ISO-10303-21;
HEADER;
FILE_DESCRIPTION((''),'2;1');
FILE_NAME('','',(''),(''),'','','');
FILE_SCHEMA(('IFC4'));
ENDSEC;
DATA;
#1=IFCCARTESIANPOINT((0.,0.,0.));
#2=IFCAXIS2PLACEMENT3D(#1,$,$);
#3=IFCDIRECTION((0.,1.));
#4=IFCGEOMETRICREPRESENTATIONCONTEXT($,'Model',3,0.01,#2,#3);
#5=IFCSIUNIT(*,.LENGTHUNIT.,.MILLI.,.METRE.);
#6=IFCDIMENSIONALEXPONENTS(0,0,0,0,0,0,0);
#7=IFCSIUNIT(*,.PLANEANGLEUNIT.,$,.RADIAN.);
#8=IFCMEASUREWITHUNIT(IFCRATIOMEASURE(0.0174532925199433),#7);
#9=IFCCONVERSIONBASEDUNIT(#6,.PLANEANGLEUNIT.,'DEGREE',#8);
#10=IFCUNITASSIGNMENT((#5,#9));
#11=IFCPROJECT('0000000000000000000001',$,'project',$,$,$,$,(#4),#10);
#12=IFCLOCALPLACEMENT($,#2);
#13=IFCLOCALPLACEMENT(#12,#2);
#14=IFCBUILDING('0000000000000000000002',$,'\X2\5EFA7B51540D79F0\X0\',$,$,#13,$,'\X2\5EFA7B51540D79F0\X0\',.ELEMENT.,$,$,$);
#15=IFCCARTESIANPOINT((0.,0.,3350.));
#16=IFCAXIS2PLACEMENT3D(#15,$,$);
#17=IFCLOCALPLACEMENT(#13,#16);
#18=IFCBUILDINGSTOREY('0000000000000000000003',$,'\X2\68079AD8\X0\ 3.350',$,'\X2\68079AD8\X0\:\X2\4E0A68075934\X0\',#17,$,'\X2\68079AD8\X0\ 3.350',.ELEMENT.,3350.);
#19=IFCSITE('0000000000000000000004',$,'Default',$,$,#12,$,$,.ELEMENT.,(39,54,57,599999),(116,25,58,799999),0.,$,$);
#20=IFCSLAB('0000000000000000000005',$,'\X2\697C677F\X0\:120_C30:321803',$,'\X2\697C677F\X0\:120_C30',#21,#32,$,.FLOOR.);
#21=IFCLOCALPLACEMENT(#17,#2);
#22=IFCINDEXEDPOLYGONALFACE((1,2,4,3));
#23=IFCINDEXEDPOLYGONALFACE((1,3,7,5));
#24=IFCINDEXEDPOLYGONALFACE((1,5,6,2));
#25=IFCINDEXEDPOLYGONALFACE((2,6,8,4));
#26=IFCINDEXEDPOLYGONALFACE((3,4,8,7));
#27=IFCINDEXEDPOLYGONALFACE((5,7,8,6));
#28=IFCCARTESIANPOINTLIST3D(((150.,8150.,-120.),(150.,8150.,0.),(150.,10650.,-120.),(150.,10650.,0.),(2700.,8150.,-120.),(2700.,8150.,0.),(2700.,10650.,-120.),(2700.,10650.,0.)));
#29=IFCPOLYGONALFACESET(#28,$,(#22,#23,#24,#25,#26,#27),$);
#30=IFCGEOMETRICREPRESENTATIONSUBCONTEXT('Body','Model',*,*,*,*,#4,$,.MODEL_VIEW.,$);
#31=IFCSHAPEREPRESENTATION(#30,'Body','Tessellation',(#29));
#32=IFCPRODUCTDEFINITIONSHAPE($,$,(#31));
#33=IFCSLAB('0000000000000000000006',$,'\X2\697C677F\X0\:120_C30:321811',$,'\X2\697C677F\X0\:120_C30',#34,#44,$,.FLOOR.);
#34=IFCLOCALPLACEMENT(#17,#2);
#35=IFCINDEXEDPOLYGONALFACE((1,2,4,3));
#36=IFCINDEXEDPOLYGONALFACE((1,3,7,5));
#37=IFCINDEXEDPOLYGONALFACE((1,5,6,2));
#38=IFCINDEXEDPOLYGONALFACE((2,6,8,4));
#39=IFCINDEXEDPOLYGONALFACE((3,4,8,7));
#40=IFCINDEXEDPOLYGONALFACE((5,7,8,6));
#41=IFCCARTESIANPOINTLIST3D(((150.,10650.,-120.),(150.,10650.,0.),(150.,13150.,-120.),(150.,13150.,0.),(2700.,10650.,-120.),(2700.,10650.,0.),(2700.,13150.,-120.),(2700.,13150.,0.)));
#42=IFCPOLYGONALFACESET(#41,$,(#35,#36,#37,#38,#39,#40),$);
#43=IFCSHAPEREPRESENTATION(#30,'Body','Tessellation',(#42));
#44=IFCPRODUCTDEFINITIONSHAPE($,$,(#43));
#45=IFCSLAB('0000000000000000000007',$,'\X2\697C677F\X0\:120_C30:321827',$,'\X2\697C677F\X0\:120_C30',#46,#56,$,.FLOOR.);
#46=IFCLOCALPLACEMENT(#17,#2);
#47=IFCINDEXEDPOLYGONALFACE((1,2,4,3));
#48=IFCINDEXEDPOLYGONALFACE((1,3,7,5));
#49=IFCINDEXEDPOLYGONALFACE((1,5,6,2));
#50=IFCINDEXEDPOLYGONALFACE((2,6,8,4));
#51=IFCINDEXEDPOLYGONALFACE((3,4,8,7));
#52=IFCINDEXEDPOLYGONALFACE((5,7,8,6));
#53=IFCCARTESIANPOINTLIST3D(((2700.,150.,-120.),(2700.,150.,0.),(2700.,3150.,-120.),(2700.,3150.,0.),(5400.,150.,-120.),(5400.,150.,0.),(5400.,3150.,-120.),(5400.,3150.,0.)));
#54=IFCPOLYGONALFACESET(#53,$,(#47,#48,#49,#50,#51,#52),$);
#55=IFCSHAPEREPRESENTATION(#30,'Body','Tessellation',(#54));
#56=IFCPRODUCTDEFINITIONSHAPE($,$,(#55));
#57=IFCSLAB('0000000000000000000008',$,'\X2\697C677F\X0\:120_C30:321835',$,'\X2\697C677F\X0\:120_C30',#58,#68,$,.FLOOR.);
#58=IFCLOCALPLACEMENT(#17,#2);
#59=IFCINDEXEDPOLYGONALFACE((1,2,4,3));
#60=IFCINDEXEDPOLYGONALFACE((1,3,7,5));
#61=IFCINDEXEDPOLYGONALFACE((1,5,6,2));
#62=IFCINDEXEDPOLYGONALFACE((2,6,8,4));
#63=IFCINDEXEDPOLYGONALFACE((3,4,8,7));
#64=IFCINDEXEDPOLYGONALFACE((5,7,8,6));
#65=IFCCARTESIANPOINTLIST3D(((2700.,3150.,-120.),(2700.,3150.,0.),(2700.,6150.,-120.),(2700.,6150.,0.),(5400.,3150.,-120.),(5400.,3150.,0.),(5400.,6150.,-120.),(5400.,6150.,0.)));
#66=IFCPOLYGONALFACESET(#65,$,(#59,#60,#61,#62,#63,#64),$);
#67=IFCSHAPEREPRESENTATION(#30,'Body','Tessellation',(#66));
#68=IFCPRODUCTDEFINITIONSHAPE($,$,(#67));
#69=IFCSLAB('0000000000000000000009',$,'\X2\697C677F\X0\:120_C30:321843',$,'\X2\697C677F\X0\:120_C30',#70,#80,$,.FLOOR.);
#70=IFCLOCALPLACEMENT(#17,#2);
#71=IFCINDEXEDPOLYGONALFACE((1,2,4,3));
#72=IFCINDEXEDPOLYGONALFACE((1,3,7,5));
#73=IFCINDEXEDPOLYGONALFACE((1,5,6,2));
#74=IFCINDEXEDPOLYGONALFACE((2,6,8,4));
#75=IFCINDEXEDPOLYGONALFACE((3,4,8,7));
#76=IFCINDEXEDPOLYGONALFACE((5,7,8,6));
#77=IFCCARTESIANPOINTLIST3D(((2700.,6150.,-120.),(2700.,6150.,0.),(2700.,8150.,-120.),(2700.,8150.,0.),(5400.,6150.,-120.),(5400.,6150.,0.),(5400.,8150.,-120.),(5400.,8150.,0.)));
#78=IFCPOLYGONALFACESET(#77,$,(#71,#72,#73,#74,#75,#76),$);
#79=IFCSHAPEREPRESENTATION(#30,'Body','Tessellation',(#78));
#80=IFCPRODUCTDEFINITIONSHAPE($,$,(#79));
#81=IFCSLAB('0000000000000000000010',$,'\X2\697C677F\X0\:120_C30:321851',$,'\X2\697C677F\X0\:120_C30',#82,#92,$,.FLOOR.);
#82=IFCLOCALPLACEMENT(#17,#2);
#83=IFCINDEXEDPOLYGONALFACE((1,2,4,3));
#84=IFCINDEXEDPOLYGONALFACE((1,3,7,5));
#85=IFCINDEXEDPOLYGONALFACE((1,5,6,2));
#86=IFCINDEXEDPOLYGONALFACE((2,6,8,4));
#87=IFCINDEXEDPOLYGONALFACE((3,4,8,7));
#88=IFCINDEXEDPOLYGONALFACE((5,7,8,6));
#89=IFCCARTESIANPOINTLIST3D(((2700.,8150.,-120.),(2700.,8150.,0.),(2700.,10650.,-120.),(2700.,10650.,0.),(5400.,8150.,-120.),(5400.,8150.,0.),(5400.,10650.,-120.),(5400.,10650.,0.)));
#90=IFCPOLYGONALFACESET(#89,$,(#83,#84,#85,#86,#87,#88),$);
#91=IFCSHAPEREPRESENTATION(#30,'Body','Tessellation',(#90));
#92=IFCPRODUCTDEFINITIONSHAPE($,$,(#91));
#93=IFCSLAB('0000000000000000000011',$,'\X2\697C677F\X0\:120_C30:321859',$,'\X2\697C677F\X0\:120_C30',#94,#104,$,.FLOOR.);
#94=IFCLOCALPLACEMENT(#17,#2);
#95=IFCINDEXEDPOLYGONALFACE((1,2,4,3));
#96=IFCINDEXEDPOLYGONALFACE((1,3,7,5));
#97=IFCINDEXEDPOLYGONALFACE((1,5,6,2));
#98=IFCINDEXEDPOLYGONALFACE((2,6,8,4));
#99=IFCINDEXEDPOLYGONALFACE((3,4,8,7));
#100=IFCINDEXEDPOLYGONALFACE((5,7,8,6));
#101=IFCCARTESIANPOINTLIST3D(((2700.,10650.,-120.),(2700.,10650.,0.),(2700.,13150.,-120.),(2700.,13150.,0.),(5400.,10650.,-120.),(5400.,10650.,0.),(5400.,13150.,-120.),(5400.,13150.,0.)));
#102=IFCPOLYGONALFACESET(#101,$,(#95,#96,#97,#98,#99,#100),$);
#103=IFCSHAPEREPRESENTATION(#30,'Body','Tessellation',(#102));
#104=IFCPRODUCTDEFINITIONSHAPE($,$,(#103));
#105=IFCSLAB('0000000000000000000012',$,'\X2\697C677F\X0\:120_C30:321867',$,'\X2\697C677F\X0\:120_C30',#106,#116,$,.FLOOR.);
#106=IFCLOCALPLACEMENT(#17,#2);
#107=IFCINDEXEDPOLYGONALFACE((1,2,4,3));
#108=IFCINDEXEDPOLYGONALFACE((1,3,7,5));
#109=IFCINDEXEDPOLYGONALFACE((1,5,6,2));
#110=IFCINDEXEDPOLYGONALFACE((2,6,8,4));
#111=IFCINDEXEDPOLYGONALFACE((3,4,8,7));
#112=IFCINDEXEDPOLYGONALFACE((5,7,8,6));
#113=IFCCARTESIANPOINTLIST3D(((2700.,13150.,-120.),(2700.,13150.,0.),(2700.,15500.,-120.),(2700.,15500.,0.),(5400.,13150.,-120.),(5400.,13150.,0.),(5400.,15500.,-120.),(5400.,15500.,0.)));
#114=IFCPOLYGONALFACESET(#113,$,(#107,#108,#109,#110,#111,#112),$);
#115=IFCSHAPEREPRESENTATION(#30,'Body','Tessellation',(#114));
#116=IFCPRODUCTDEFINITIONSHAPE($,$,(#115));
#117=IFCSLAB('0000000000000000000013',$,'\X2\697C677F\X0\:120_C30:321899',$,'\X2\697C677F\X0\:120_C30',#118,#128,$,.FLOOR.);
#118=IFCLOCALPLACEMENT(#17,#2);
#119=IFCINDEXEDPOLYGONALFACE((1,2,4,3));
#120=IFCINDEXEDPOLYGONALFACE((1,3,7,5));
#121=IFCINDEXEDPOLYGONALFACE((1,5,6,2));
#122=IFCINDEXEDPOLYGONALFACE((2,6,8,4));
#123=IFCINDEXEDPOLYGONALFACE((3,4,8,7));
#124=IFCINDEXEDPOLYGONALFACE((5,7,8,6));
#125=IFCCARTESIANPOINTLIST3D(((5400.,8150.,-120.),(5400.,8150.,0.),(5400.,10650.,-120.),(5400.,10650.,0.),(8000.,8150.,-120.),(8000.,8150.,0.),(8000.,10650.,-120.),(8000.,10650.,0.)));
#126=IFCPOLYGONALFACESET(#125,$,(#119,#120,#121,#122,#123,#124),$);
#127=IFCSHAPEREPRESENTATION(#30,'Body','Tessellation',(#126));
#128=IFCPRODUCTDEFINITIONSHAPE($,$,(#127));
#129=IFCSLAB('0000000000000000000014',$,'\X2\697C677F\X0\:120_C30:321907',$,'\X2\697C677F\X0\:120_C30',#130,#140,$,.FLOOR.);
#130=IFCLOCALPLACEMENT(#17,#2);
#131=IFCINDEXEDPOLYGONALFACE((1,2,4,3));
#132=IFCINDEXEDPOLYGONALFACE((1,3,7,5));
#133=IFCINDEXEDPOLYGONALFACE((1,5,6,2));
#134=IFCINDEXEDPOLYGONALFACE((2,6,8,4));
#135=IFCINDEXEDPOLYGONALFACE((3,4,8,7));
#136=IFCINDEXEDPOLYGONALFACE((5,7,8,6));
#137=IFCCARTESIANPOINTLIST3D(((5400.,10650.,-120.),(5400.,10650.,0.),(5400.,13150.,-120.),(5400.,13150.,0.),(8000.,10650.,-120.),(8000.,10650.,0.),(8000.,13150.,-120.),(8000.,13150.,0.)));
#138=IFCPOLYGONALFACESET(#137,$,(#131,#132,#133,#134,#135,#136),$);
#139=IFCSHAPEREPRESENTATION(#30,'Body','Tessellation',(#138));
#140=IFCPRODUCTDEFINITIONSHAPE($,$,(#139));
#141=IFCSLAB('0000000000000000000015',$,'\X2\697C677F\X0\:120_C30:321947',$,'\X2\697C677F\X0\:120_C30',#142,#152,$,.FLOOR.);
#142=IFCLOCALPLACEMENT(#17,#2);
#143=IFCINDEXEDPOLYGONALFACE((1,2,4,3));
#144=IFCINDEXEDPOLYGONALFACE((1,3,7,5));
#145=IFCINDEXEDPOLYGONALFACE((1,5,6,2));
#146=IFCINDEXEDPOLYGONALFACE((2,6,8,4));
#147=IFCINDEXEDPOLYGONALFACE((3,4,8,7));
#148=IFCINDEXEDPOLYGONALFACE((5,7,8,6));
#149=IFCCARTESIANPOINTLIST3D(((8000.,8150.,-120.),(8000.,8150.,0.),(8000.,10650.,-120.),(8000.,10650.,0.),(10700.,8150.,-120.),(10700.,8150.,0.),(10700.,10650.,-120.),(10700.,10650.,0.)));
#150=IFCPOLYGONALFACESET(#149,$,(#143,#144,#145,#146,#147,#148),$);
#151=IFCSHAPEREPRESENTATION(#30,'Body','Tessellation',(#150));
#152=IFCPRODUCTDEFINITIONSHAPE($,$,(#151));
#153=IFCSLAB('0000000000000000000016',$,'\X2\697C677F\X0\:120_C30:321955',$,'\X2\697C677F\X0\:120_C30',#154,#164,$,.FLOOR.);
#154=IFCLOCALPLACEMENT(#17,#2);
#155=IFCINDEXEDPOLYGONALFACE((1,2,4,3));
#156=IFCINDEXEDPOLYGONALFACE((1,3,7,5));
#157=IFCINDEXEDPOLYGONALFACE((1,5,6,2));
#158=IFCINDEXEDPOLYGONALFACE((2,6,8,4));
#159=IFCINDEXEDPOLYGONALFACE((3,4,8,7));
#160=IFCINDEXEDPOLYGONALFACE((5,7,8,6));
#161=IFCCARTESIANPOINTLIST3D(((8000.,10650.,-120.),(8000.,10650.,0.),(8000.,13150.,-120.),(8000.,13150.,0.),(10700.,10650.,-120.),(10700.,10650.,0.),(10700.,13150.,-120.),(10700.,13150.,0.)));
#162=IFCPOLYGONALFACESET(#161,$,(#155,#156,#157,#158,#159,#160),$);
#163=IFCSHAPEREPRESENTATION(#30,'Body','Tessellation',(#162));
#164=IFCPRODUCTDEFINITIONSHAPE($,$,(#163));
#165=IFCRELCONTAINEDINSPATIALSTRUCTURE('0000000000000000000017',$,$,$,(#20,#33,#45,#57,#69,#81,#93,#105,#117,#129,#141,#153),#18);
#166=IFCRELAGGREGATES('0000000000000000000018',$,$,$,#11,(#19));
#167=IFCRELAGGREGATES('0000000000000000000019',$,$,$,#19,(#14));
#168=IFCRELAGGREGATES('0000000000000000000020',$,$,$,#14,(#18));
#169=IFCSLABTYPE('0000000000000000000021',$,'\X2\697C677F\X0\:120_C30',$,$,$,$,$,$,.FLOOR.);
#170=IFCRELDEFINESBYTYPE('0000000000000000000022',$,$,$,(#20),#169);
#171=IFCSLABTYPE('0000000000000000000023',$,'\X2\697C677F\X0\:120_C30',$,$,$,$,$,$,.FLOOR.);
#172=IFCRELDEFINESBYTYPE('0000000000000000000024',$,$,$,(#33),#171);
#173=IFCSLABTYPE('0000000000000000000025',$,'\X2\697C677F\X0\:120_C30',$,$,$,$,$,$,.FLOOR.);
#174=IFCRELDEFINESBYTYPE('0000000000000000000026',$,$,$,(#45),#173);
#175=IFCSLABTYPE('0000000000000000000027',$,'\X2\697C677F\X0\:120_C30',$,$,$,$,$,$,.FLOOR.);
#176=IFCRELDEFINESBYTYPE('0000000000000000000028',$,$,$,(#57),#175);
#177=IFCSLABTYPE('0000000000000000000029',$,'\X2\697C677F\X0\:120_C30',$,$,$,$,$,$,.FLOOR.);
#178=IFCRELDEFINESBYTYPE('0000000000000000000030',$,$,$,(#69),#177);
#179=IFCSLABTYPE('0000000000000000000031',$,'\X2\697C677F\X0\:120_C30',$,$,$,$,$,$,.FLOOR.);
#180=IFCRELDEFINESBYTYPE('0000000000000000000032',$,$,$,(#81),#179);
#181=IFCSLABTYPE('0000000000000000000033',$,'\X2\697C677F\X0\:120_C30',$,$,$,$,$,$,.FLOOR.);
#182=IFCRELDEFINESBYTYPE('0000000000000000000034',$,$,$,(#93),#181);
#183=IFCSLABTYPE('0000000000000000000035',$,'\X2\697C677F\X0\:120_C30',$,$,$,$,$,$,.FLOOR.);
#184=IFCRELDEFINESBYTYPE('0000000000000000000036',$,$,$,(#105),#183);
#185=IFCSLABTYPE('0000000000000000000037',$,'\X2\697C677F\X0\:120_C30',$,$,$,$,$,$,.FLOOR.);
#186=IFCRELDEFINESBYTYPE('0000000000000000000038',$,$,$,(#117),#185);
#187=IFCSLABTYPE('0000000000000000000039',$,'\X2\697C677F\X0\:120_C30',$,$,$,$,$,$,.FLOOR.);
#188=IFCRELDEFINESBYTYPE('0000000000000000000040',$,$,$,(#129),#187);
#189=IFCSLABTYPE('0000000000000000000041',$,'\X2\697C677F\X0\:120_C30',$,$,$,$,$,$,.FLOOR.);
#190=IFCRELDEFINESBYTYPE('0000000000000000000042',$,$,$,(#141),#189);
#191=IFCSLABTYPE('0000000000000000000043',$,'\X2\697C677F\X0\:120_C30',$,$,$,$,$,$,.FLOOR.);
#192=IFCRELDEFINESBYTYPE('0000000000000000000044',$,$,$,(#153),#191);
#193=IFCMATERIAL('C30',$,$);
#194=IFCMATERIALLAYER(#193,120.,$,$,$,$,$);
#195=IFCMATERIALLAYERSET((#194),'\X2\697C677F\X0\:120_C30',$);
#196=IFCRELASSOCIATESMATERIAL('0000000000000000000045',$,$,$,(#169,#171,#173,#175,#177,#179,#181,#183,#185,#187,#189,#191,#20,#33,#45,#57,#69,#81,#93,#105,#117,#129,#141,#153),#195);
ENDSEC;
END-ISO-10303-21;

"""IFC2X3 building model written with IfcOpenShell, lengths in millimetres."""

from ifc_helpers import new_model, entity, si_unit, converted_unit, direction, frame, frame_2d, origin, origin_2d_with_axis, place, context, subcontext, project, spatial, rectangle, extrude, material, layer, layer_set, layer_usage, type_object, element, save


model = new_model("IFC2X3")

# Units and contexts
model_context = context("Model", 3, precision=0.01, world=origin(), true_north=direction((0.0, 1.0)))
body_context = subcontext(model_context, "Body", "Model", "MODEL_VIEW")
ifc_project = project(units=[si_unit("LENGTHUNIT", "METRE", prefix="MILLI"), converted_unit("PLANEANGLEUNIT", "DEGREE", entity("IfcRatioMeasure", 0.0174532925199433), si_unit("PLANEANGLEUNIT", "RADIAN"), dimensions=[0, 0, 0, 0, 0, 0, 0])], contexts=[model_context])

# Site, building, storey
site_placement = place(None, origin())
site = spatial("IfcSite", under=ifc_project, at=site_placement, Name="Default", CompositionType="ELEMENT", RefLatitude=(39, 54, 57, 599999), RefLongitude=(116, 25, 58, 799999), RefElevation=0.0)
building_placement = place(site_placement, origin())
building = spatial("IfcBuilding", under=site, at=building_placement, Name="建筑名称", LongName="建筑名称", CompositionType="ELEMENT")
storey_placement = place(building_placement, frame((0.0, 0.0, 3350.0)))
storey = spatial("IfcBuildingStorey", under=building, at=storey_placement, Name="标高 3.350", ObjectType="标高:上标头", LongName="标高 3.350", CompositionType="ELEMENT", Elevation=3350.0)

# Slabs
ifc_material = material(Name="C30")
ifc_layer = layer(ifc_material, 120.0)
ifc_layer_set = layer_set([ifc_layer], Name="楼板:120_C30")
ifc_layer_usage_1 = layer_usage(ifc_layer_set, "AXIS3", "POSITIVE", 0.0)
slab_type_1 = type_object("IfcSlabType", Name="楼板:120_C30", PredefinedType="FLOOR", material=ifc_layer_set)
slab_1_placement = place(storey_placement, origin())
element("IfcSlab", 1, at=slab_1_placement, inside=storey, type_object=slab_type_1, material=ifc_layer_usage_1, Name="楼板:120_C30:321803", ObjectType="楼板:120_C30", PredefinedType="FLOOR", context=body_context, shape_type="SweptSolid", body=[
    extrude(rectangle(XDim=2500.0, YDim=2550.0, at=frame_2d((0.0, 0.0), x_axis=(1.0, 0.0))), frame((1425.0, 9400.0, 0.0), z_axis=(0.0, 0.0, -1.0), x_axis=(0.0, 1.0, 0.0)), (0.0, 0.0, 1.0), 120.0),
])
ifc_layer_usage_2 = layer_usage(ifc_layer_set, "AXIS3", "POSITIVE", 0.0)
slab_type_2 = type_object("IfcSlabType", Name="楼板:120_C30", PredefinedType="FLOOR", material=ifc_layer_set)
slab_2_placement = place(storey_placement, origin())
element("IfcSlab", 2, at=slab_2_placement, inside=storey, type_object=slab_type_2, material=ifc_layer_usage_2, Name="楼板:120_C30:321811", ObjectType="楼板:120_C30", PredefinedType="FLOOR", context=body_context, shape_type="SweptSolid", body=[
    extrude(rectangle(XDim=2500.0, YDim=2550.0, at=origin_2d_with_axis()), frame((1425.0, 11900.0, 0.0), z_axis=(0.0, 0.0, -1.0), x_axis=(0.0, 1.0, 0.0)), (0.0, 0.0, 1.0), 120.0),
])
ifc_layer_usage_3 = layer_usage(ifc_layer_set, "AXIS3", "POSITIVE", 0.0)
slab_type_3 = type_object("IfcSlabType", Name="楼板:120_C30", PredefinedType="FLOOR", material=ifc_layer_set)
slab_3_placement = place(storey_placement, origin())
element("IfcSlab", 3, at=slab_3_placement, inside=storey, type_object=slab_type_3, material=ifc_layer_usage_3, Name="楼板:120_C30:321827", ObjectType="楼板:120_C30", PredefinedType="FLOOR", context=body_context, shape_type="SweptSolid", body=[
    extrude(rectangle(XDim=3000.0, YDim=2700.0, at=origin_2d_with_axis()), frame((4050.0, 1650.0, 0.0), z_axis=(0.0, 0.0, -1.0), x_axis=(0.0, 1.0, 0.0)), (0.0, 0.0, 1.0), 120.0),
])
ifc_layer_usage_4 = layer_usage(ifc_layer_set, "AXIS3", "POSITIVE", 0.0)
slab_type_4 = type_object("IfcSlabType", Name="楼板:120_C30", PredefinedType="FLOOR", material=ifc_layer_set)
slab_4_placement = place(storey_placement, origin())
element("IfcSlab", 4, at=slab_4_placement, inside=storey, type_object=slab_type_4, material=ifc_layer_usage_4, Name="楼板:120_C30:321835", ObjectType="楼板:120_C30", PredefinedType="FLOOR", context=body_context, shape_type="SweptSolid", body=[
    extrude(rectangle(XDim=3000.0, YDim=2700.0, at=frame_2d((0.0, 0.0), x_axis=(1.0, 0.0))), frame((4050.0, 4650.0, 0.0), z_axis=(0.0, 0.0, -1.0), x_axis=(0.0, 1.0, 0.0)), (0.0, 0.0, 1.0), 120.0),
])
ifc_layer_usage_5 = layer_usage(ifc_layer_set, "AXIS3", "POSITIVE", 0.0)
slab_type_5 = type_object("IfcSlabType", Name="楼板:120_C30", PredefinedType="FLOOR", material=ifc_layer_set)
slab_5_placement = place(storey_placement, origin())
element("IfcSlab", 5, at=slab_5_placement, inside=storey, type_object=slab_type_5, material=ifc_layer_usage_5, Name="楼板:120_C30:321843", ObjectType="楼板:120_C30", PredefinedType="FLOOR", context=body_context, shape_type="SweptSolid", body=[
    extrude(rectangle(XDim=2000.0, YDim=2700.0, at=origin_2d_with_axis()), frame((4050.0, 7150.0, 0.0), z_axis=(0.0, 0.0, -1.0), x_axis=(0.0, 1.0, 0.0)), (0.0, 0.0, 1.0), 120.0),
])
ifc_layer_usage_6 = layer_usage(ifc_layer_set, "AXIS3", "POSITIVE", 0.0)
slab_type_6 = type_object("IfcSlabType", Name="楼板:120_C30", PredefinedType="FLOOR", material=ifc_layer_set)
slab_6_placement = place(storey_placement, origin())
element("IfcSlab", 6, at=slab_6_placement, inside=storey, type_object=slab_type_6, material=ifc_layer_usage_6, Name="楼板:120_C30:321851", ObjectType="楼板:120_C30", PredefinedType="FLOOR", context=body_context, shape_type="SweptSolid", body=[
    extrude(rectangle(XDim=2500.0, YDim=2700.0, at=frame_2d((0.0, 0.0), x_axis=(1.0, 0.0))), frame((4050.0, 9400.0, 0.0), z_axis=(0.0, 0.0, -1.0), x_axis=(0.0, 1.0, 0.0)), (0.0, 0.0, 1.0), 120.0),
])
ifc_layer_usage_7 = layer_usage(ifc_layer_set, "AXIS3", "POSITIVE", 0.0)
slab_type_7 = type_object("IfcSlabType", Name="楼板:120_C30", PredefinedType="FLOOR", material=ifc_layer_set)
slab_7_placement = place(storey_placement, origin())
element("IfcSlab", 7, at=slab_7_placement, inside=storey, type_object=slab_type_7, material=ifc_layer_usage_7, Name="楼板:120_C30:321859", ObjectType="楼板:120_C30", PredefinedType="FLOOR", context=body_context, shape_type="SweptSolid", body=[
    extrude(rectangle(XDim=2500.0, YDim=2700.0, at=origin_2d_with_axis()), frame((4050.0, 11900.0, 0.0), z_axis=(0.0, 0.0, -1.0), x_axis=(0.0, 1.0, 0.0)), (0.0, 0.0, 1.0), 120.0),
])
ifc_layer_usage_8 = layer_usage(ifc_layer_set, "AXIS3", "POSITIVE", 0.0)
slab_type_8 = type_object("IfcSlabType", Name="楼板:120_C30", PredefinedType="FLOOR", material=ifc_layer_set)
slab_8_placement = place(storey_placement, origin())
element("IfcSlab", 8, at=slab_8_placement, inside=storey, type_object=slab_type_8, material=ifc_layer_usage_8, Name="楼板:120_C30:321867", ObjectType="楼板:120_C30", PredefinedType="FLOOR", context=body_context, shape_type="SweptSolid", body=[
    extrude(rectangle(XDim=2350.0, YDim=2700.0, at=frame_2d((0.0, 0.0), x_axis=(1.0, 0.0))), frame((4050.0, 14325.0, 0.0), z_axis=(0.0, 0.0, -1.0), x_axis=(0.0, 1.0, 0.0)), (0.0, 0.0, 1.0), 120.0),
])
ifc_layer_usage_9 = layer_usage(ifc_layer_set, "AXIS3", "POSITIVE", 0.0)
slab_type_9 = type_object("IfcSlabType", Name="楼板:120_C30", PredefinedType="FLOOR", material=ifc_layer_set)
slab_9_placement = place(storey_placement, origin())
element("IfcSlab", 9, at=slab_9_placement, inside=storey, type_object=slab_type_9, material=ifc_layer_usage_9, Name="楼板:120_C30:321899", ObjectType="楼板:120_C30", PredefinedType="FLOOR", context=body_context, shape_type="SweptSolid", body=[
    extrude(rectangle(XDim=2500.0, YDim=2600.0, at=frame_2d((0.0, 0.0), x_axis=(1.0, 0.0))), frame((6700.0, 9400.0, 0.0), z_axis=(0.0, 0.0, -1.0), x_axis=(0.0, 1.0, 0.0)), (0.0, 0.0, 1.0), 120.0),
])
ifc_layer_usage_10 = layer_usage(ifc_layer_set, "AXIS3", "POSITIVE", 0.0)
slab_type_10 = type_object("IfcSlabType", Name="楼板:120_C30", PredefinedType="FLOOR", material=ifc_layer_set)
slab_10_placement = place(storey_placement, origin())
element("IfcSlab", 10, at=slab_10_placement, inside=storey, type_object=slab_type_10, material=ifc_layer_usage_10, Name="楼板:120_C30:321907", ObjectType="楼板:120_C30", PredefinedType="FLOOR", context=body_context, shape_type="SweptSolid", body=[
    extrude(rectangle(XDim=2500.0, YDim=2600.0, at=origin_2d_with_axis()), frame((6700.0, 11900.0, 0.0), z_axis=(0.0, 0.0, -1.0), x_axis=(0.0, 1.0, 0.0)), (0.0, 0.0, 1.0), 120.0),
])
ifc_layer_usage_11 = layer_usage(ifc_layer_set, "AXIS3", "POSITIVE", 0.0)
slab_type_11 = type_object("IfcSlabType", Name="楼板:120_C30", PredefinedType="FLOOR", material=ifc_layer_set)
slab_11_placement = place(storey_placement, origin())
element("IfcSlab", 11, at=slab_11_placement, inside=storey, type_object=slab_type_11, material=ifc_layer_usage_11, Name="楼板:120_C30:321947", ObjectType="楼板:120_C30", PredefinedType="FLOOR", context=body_context, shape_type="SweptSolid", body=[
    extrude(rectangle(XDim=2500.0, YDim=2700.0, at=frame_2d((0.0, 0.0), x_axis=(1.0, 0.0))), frame((9350.0, 9400.0, 0.0), z_axis=(0.0, 0.0, -1.0), x_axis=(0.0, 1.0, 0.0)), (0.0, 0.0, 1.0), 120.0),
])
ifc_layer_usage_12 = layer_usage(ifc_layer_set, "AXIS3", "POSITIVE", 0.0)
slab_type_12 = type_object("IfcSlabType", Name="楼板:120_C30", PredefinedType="FLOOR", material=ifc_layer_set)
slab_12_placement = place(storey_placement, origin())
element("IfcSlab", 12, at=slab_12_placement, inside=storey, type_object=slab_type_12, material=ifc_layer_usage_12, Name="楼板:120_C30:321955", ObjectType="楼板:120_C30", PredefinedType="FLOOR", context=body_context, shape_type="SweptSolid", body=[
    extrude(rectangle(XDim=2500.0, YDim=2700.0, at=frame_2d((0.0, 0.0), x_axis=(1.0, 0.0))), frame((9350.0, 11900.0, 0.0), z_axis=(0.0, 0.0, -1.0), x_axis=(0.0, 1.0, 0.0)), (0.0, 0.0, 1.0), 120.0),
])

save(model, "model.ifc")
